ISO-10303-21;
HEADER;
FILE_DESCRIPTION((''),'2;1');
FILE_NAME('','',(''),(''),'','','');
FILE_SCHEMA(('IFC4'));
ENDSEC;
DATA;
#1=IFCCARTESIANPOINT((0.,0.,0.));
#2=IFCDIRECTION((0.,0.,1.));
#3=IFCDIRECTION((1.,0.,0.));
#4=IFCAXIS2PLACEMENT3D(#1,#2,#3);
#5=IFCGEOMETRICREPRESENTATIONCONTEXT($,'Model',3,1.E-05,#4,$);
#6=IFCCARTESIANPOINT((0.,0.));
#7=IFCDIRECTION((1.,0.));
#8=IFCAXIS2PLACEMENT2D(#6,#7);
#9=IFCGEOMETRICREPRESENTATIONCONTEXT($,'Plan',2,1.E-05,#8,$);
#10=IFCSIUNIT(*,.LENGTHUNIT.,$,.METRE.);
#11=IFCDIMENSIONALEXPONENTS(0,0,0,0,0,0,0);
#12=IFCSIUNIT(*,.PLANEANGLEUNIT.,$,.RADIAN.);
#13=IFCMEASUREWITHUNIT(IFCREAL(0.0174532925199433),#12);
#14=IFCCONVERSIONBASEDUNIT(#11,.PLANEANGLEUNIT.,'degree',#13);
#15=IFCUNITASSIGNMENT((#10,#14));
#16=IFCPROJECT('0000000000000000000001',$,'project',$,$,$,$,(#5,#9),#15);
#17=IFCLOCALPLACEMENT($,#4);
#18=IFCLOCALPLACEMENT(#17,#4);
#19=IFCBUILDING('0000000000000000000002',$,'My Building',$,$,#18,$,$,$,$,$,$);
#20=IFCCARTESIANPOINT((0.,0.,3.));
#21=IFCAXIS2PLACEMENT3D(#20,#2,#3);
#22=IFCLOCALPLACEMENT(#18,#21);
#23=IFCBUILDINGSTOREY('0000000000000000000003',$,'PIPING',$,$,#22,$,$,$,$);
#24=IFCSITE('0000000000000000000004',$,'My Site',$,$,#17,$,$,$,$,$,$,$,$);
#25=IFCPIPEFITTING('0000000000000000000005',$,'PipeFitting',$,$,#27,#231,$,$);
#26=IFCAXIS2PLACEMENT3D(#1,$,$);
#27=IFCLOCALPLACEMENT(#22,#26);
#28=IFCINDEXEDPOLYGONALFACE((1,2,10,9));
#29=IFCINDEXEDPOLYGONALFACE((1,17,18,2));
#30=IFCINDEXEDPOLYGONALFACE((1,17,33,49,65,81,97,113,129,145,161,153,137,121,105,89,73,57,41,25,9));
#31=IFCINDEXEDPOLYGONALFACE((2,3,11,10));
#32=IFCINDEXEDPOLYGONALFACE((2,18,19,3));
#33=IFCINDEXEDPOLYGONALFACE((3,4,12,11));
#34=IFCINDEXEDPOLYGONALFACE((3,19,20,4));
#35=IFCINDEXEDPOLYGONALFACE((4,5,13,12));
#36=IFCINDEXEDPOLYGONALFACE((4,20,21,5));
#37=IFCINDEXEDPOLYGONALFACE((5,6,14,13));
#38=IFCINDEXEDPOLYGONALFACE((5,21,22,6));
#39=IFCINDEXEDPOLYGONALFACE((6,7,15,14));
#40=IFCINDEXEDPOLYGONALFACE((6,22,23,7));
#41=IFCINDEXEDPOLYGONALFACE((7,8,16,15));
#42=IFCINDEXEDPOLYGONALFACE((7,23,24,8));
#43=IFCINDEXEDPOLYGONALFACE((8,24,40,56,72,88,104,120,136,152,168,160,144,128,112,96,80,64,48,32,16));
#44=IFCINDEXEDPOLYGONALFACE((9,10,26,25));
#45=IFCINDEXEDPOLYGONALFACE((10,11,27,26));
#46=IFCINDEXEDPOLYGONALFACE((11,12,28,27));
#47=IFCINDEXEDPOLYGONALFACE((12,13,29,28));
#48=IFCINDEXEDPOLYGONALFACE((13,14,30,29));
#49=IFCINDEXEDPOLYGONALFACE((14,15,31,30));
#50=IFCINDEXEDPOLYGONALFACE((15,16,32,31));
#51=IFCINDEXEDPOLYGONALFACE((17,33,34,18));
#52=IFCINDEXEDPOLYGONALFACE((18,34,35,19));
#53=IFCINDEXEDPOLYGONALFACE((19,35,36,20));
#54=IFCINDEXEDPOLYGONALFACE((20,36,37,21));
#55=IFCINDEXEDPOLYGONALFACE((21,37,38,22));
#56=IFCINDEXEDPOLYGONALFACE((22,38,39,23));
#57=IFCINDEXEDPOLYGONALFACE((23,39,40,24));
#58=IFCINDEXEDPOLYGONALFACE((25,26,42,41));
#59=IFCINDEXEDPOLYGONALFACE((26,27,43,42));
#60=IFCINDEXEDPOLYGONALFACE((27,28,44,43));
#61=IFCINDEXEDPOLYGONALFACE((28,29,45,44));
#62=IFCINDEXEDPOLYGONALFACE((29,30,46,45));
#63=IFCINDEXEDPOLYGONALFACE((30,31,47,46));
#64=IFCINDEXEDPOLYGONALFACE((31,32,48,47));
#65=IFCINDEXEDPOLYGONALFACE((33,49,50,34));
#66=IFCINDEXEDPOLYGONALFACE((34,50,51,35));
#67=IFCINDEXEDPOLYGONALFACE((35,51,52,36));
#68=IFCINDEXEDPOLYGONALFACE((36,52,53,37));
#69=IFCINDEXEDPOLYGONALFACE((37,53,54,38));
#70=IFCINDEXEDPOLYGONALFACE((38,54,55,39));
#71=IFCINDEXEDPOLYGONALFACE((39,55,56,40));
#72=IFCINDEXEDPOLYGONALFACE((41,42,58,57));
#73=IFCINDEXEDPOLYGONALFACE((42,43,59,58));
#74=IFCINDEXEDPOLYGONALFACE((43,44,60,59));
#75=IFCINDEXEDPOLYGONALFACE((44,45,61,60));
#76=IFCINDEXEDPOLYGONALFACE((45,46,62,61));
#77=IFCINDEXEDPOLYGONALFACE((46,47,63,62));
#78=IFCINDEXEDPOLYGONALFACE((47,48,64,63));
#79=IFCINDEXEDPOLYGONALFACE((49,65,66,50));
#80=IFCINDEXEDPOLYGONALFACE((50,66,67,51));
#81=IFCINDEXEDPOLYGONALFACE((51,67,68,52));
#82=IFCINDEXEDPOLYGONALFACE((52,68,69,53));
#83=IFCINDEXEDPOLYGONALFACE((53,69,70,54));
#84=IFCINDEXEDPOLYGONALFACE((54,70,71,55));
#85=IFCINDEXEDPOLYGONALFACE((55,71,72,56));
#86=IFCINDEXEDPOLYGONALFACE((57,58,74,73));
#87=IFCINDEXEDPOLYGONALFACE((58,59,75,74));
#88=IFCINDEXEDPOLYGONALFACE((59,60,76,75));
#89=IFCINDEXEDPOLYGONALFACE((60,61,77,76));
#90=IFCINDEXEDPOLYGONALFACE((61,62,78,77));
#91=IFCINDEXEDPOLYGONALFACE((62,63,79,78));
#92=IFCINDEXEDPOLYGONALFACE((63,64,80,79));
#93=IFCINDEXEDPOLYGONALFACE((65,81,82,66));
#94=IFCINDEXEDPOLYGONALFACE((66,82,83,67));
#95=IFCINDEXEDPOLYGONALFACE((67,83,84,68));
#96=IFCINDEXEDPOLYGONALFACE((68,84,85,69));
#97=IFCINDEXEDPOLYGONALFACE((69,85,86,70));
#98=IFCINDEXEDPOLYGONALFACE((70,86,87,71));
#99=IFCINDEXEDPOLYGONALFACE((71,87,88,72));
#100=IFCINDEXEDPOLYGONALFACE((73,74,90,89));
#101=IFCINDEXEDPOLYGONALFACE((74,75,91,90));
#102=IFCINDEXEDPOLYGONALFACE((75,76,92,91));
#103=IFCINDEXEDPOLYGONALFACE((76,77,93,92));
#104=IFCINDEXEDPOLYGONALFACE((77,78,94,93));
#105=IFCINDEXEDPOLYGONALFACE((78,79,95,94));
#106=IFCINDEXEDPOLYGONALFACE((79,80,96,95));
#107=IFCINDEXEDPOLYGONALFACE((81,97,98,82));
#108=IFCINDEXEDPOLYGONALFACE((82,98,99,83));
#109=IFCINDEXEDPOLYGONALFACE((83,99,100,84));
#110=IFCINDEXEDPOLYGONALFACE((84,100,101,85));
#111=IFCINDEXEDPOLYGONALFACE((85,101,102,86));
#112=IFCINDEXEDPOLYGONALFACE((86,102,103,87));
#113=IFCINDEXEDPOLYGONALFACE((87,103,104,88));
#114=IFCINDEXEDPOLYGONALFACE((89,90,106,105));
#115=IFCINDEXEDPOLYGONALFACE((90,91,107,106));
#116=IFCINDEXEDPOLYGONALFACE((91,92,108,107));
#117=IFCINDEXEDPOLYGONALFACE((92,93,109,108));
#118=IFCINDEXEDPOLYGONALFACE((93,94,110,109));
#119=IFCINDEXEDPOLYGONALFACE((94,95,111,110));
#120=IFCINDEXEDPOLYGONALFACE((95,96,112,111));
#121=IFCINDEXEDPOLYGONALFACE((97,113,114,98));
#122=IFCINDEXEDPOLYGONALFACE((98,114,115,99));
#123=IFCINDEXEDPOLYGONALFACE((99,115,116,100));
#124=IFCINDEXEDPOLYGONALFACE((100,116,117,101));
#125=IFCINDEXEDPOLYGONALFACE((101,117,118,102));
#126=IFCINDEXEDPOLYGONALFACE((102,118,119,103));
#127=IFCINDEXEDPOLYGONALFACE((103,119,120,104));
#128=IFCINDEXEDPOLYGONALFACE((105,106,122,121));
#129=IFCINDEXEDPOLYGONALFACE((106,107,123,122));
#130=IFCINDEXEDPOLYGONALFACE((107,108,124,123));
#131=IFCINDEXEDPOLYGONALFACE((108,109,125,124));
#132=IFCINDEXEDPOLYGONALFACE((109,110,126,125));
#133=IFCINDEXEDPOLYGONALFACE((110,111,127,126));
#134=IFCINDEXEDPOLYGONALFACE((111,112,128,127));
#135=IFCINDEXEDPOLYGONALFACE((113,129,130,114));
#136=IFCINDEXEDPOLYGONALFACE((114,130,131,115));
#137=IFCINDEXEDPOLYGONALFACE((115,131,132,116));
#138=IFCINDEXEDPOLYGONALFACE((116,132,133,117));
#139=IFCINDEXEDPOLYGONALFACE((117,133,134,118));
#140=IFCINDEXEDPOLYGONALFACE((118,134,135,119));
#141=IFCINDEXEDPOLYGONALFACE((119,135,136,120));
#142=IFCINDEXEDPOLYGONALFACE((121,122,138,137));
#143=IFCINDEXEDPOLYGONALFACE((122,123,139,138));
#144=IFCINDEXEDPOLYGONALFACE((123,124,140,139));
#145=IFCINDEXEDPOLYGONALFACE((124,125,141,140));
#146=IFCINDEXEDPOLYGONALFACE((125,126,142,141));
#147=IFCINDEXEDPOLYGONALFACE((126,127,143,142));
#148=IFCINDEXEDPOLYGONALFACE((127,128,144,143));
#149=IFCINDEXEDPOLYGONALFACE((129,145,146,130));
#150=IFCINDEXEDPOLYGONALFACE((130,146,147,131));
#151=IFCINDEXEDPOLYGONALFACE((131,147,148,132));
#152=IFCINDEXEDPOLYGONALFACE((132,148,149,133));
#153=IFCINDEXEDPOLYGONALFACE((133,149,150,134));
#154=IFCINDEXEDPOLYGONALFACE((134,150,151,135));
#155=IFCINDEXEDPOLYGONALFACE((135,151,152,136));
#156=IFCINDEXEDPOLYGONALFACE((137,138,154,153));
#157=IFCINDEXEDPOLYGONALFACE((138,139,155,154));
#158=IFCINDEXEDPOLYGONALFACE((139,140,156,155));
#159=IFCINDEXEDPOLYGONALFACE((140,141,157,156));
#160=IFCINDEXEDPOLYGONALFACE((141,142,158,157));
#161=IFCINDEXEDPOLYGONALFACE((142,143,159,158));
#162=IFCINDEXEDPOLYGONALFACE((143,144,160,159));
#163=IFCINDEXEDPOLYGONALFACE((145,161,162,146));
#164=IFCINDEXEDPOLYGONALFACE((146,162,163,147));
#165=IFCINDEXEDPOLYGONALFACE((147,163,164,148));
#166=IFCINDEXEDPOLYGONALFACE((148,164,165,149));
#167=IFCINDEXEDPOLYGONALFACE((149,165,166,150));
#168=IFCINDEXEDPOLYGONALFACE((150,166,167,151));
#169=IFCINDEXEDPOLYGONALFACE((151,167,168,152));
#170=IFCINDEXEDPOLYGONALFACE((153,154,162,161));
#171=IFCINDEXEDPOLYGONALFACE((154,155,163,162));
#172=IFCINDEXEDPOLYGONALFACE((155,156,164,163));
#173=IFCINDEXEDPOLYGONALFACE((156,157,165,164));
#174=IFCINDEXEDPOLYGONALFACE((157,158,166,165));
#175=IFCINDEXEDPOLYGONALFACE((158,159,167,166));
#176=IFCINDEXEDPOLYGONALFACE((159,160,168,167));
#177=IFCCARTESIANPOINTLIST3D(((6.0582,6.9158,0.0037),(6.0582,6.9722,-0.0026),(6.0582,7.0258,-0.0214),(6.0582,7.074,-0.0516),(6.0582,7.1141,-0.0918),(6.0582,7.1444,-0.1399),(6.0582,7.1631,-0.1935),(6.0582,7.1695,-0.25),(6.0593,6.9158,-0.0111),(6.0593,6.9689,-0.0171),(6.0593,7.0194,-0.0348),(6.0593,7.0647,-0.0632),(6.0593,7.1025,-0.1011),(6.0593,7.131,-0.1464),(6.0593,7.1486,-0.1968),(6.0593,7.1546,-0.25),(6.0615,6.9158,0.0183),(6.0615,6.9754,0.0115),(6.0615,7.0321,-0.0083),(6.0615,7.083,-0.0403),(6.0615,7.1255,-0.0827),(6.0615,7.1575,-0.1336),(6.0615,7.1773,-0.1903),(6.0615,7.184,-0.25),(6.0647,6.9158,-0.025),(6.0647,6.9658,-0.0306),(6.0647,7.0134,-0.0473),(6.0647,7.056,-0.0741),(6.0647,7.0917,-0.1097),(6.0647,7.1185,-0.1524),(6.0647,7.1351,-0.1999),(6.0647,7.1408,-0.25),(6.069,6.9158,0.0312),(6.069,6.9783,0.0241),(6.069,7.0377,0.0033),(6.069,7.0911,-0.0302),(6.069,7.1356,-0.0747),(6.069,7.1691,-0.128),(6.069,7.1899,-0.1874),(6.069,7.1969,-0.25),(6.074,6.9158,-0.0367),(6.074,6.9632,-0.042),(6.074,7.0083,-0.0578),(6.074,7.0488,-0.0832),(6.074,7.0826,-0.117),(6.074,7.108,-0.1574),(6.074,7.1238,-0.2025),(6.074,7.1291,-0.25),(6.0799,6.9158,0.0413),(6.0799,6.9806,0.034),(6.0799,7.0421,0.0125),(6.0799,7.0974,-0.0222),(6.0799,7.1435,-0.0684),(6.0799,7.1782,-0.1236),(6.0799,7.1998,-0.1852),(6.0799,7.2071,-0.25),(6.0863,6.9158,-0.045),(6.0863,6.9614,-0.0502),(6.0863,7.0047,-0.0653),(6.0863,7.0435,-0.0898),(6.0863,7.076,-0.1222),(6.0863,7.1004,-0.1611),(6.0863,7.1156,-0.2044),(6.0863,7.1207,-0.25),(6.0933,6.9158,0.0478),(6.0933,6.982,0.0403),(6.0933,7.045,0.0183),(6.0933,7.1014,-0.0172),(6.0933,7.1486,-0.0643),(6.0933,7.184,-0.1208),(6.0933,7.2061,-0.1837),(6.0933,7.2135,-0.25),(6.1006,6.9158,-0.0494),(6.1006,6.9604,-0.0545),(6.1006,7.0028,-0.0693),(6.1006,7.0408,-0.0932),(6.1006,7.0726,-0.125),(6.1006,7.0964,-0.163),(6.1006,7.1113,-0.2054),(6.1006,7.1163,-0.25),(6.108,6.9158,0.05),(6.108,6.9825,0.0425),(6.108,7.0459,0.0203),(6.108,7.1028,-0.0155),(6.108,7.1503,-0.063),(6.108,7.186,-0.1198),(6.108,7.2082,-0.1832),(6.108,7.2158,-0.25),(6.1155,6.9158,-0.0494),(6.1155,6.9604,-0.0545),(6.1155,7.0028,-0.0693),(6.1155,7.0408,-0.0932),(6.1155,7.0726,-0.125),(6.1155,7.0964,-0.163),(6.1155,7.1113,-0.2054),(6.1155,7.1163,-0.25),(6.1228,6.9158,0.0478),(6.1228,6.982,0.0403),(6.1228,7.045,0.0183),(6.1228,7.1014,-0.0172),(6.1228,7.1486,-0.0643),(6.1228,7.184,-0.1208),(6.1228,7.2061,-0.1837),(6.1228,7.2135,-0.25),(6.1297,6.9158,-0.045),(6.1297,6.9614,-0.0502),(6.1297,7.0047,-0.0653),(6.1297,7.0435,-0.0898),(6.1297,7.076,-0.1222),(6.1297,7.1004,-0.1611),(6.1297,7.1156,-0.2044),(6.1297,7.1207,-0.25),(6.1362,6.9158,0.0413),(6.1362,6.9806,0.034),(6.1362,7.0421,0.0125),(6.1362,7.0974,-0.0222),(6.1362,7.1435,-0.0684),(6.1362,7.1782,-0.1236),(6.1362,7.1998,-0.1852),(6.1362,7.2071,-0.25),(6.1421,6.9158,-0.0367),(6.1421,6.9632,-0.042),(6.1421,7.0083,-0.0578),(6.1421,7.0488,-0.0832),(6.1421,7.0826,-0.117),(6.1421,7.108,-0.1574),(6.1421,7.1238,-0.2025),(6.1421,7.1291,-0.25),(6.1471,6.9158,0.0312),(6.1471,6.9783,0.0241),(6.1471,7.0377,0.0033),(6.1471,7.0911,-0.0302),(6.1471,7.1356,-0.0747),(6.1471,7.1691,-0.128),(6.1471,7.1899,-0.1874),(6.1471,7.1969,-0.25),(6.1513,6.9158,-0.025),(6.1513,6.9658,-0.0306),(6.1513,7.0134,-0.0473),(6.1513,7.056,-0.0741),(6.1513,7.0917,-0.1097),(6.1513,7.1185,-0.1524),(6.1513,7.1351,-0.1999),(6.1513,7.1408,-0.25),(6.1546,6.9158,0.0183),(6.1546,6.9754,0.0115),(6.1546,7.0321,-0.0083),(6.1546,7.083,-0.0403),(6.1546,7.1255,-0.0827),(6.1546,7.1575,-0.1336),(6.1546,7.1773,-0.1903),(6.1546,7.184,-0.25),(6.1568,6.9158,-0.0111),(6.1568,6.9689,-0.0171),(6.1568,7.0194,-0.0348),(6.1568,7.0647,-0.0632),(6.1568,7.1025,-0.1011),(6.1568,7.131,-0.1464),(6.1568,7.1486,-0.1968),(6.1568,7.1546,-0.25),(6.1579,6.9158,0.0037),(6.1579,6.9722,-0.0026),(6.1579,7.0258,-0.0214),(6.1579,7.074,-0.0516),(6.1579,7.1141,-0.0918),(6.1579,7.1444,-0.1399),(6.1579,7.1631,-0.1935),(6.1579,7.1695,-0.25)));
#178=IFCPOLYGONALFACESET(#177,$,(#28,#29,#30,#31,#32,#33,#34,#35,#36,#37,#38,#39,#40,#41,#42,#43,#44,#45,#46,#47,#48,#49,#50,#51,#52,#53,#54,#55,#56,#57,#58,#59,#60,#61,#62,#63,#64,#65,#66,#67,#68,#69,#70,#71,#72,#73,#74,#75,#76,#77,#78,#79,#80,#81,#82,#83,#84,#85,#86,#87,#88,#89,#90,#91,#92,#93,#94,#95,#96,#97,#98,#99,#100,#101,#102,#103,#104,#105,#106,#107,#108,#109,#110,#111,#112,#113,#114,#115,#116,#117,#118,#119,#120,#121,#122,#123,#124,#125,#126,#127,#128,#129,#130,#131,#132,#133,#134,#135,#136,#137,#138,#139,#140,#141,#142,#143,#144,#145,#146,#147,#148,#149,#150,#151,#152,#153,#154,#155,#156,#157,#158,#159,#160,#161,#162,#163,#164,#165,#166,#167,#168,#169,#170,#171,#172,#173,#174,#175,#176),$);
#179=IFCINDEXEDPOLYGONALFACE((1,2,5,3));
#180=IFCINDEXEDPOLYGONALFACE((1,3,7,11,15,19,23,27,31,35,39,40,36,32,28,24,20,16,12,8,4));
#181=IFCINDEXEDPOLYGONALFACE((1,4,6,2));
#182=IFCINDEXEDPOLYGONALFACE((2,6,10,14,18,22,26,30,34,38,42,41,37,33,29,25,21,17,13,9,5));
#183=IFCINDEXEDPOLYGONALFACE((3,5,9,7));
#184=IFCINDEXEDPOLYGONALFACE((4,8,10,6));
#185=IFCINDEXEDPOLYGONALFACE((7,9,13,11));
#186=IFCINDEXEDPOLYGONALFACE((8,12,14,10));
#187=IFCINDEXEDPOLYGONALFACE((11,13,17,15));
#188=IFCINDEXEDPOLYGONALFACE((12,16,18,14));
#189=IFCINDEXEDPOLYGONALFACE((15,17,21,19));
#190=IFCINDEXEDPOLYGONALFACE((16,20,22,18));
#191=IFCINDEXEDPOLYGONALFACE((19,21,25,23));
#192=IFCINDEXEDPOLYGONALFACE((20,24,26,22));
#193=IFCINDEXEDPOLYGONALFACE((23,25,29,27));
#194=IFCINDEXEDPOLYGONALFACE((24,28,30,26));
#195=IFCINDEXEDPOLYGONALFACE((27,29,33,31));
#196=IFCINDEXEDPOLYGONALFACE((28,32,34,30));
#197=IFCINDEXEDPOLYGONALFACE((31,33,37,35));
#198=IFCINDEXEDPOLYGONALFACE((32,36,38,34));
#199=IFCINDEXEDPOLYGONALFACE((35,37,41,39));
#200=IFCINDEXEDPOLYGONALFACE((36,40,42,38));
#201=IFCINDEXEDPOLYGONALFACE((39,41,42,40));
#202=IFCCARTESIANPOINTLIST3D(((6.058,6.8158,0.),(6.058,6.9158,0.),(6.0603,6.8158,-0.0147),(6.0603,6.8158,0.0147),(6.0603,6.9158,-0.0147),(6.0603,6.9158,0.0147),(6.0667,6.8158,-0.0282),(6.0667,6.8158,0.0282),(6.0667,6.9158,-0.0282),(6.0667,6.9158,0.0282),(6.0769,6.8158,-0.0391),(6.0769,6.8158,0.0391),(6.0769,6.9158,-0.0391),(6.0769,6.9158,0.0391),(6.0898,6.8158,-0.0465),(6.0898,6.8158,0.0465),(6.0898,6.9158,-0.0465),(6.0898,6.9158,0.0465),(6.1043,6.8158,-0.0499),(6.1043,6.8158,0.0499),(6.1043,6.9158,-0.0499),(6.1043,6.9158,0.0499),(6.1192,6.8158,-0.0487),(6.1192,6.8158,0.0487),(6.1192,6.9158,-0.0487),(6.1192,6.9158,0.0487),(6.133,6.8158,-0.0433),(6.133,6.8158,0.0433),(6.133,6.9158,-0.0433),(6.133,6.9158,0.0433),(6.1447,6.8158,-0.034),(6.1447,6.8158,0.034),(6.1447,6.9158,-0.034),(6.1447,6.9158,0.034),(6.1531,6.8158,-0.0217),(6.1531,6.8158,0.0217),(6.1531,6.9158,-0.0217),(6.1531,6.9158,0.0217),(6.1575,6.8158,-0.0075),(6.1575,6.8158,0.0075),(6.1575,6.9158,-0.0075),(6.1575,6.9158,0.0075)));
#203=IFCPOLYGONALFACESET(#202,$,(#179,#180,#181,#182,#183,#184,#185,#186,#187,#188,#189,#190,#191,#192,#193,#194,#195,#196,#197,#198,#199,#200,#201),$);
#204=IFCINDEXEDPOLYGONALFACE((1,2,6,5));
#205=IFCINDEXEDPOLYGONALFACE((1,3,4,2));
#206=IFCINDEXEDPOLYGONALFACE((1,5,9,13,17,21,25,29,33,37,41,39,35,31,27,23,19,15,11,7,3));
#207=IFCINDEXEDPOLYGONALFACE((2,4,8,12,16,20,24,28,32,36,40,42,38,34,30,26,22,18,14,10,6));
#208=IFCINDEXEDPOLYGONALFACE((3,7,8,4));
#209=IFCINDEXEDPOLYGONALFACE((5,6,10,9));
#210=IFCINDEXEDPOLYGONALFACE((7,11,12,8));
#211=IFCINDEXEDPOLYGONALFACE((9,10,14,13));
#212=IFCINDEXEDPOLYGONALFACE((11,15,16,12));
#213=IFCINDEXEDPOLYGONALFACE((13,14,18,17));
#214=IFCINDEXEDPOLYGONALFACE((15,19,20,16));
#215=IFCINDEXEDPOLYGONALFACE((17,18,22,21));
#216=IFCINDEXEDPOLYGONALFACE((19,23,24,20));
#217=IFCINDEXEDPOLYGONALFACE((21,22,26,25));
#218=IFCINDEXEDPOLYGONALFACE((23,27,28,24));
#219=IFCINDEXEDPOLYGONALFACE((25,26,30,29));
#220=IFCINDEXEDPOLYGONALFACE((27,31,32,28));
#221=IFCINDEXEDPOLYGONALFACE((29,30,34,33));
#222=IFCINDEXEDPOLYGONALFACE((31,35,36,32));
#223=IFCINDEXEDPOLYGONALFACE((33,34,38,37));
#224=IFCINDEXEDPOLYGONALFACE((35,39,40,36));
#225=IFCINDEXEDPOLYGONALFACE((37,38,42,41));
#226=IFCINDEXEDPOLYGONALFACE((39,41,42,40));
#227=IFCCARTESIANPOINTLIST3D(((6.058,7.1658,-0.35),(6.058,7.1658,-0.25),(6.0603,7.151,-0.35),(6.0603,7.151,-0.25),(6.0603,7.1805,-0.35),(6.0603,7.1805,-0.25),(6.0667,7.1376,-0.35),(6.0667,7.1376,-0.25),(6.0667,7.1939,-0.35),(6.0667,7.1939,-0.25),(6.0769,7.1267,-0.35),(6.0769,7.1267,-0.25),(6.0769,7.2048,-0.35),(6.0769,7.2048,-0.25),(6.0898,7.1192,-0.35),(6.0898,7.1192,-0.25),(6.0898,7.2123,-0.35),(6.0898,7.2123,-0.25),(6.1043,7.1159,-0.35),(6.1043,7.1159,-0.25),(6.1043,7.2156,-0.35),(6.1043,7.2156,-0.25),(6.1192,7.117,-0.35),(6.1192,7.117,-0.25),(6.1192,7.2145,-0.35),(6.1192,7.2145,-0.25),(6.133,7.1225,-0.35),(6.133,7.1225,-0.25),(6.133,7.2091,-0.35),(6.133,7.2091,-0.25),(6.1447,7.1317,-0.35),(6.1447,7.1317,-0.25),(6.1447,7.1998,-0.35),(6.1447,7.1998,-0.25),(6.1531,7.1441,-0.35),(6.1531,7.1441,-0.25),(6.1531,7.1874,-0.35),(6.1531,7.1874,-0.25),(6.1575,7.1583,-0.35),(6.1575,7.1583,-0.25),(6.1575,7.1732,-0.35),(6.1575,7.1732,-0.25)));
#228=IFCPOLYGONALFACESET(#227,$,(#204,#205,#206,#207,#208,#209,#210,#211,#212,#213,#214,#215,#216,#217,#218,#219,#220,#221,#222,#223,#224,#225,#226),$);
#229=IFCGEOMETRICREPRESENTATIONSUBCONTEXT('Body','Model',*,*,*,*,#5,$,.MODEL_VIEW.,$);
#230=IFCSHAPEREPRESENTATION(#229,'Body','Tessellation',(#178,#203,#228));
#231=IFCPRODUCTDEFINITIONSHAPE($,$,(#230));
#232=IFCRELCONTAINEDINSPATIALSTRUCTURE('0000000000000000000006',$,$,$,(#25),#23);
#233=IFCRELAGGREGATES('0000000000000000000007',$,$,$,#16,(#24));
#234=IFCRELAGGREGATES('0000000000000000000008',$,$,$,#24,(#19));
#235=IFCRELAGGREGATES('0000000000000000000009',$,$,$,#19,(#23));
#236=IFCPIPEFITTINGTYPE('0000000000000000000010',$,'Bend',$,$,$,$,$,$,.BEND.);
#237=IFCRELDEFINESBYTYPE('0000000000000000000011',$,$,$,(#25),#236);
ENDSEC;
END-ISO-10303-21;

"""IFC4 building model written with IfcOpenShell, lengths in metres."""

from ifc_helpers import new_model, entity, si_unit, converted_unit, frame, origin_with_axes, origin_2d_with_axis, place, context, subcontext, project, spatial, circle, extrude, source, transform, mapped, type_object, type_shapes, element, save


model = new_model("IFC4")

# Units and contexts
model_context = context("Model", 3, precision=1e-05, world=origin_with_axes())
plan_context = context("Plan", 2, precision=1e-05, world=origin_2d_with_axis())
body_context = subcontext(model_context, "Body", "Model", "MODEL_VIEW")
ifc_project = project(units=[si_unit("LENGTHUNIT", "METRE"), converted_unit("PLANEANGLEUNIT", "degree", entity("IfcReal", 0.0174532925199433), si_unit("PLANEANGLEUNIT", "RADIAN"), dimensions=[0, 0, 0, 0, 0, 0, 0])], contexts=[model_context, plan_context])

# Site, building, storey
site_placement = place(None, origin_with_axes())
site = spatial("IfcSite", under=ifc_project, at=site_placement, Name="My Site")
building_placement = place(site_placement, origin_with_axes())
building = spatial("IfcBuilding", under=site, at=building_placement, Name="My Building")
storey_placement = place(building_placement, frame((0.0, 0.0, 3.0), z_axis=(0.0, 0.0, 1.0), x_axis=(1.0, 0.0, 0.0)))
storey = spatial("IfcBuildingStorey", under=building, at=storey_placement, Name="PIPING")

# Pipe fitting
pipe_fitting_type = type_object("IfcPipeFittingType", Name="Bend", PredefinedType="BEND")
shared_shape = source(origin_with_axes(), body_context, "Body", "SolidModel", [
    entity("IfcSweptDiskSolid", entity("IfcIndexedPolyCurve", entity("IfcCartesianPointList3D", [[0.0, 0.0, 0.1], [0.0, -0.0732, 0.2768], [0.0, -0.25, 0.35]]), [entity("IfcArcIndex", [1, 2, 3])]), 0.05),
    extrude(circle(Radius=0.05), origin_with_axes(), (0.0, 0.0, 1.0), 0.1),
    extrude(circle(Radius=0.05), frame((0.0, -0.25, 0.35), z_axis=(0.0, -1.0, 0.0), x_axis=(1.0, 0.0, 0.0)), (0.0, 0.0, 1.0), 0.1),
])
type_shapes(pipe_fitting_type, [shared_shape])
for number, where, z_axis, x_axis, name in (
    (1, (6.108, 6.8158, 0.0), (0.0, 1.0, 0.0), (-1.0, 0.0, 0.0), "PipeFitting"),
):
    element("IfcPipeFitting", number, at=place(storey_placement, frame(where, z_axis=z_axis, x_axis=x_axis)), inside=storey, type_object=pipe_fitting_type, Name=name, context=body_context, shape_type="MappedRepresentation", body=[
        mapped(shared_shape, transform((0.0, 0.0, 0.0), x_axis=(1.0, 0.0, 0.0), y_axis=(0.0, 1.0, 0.0), z_axis=(0.0, 0.0, 1.0), scale=1.0)),
    ])

save(model, "model.ifc")
